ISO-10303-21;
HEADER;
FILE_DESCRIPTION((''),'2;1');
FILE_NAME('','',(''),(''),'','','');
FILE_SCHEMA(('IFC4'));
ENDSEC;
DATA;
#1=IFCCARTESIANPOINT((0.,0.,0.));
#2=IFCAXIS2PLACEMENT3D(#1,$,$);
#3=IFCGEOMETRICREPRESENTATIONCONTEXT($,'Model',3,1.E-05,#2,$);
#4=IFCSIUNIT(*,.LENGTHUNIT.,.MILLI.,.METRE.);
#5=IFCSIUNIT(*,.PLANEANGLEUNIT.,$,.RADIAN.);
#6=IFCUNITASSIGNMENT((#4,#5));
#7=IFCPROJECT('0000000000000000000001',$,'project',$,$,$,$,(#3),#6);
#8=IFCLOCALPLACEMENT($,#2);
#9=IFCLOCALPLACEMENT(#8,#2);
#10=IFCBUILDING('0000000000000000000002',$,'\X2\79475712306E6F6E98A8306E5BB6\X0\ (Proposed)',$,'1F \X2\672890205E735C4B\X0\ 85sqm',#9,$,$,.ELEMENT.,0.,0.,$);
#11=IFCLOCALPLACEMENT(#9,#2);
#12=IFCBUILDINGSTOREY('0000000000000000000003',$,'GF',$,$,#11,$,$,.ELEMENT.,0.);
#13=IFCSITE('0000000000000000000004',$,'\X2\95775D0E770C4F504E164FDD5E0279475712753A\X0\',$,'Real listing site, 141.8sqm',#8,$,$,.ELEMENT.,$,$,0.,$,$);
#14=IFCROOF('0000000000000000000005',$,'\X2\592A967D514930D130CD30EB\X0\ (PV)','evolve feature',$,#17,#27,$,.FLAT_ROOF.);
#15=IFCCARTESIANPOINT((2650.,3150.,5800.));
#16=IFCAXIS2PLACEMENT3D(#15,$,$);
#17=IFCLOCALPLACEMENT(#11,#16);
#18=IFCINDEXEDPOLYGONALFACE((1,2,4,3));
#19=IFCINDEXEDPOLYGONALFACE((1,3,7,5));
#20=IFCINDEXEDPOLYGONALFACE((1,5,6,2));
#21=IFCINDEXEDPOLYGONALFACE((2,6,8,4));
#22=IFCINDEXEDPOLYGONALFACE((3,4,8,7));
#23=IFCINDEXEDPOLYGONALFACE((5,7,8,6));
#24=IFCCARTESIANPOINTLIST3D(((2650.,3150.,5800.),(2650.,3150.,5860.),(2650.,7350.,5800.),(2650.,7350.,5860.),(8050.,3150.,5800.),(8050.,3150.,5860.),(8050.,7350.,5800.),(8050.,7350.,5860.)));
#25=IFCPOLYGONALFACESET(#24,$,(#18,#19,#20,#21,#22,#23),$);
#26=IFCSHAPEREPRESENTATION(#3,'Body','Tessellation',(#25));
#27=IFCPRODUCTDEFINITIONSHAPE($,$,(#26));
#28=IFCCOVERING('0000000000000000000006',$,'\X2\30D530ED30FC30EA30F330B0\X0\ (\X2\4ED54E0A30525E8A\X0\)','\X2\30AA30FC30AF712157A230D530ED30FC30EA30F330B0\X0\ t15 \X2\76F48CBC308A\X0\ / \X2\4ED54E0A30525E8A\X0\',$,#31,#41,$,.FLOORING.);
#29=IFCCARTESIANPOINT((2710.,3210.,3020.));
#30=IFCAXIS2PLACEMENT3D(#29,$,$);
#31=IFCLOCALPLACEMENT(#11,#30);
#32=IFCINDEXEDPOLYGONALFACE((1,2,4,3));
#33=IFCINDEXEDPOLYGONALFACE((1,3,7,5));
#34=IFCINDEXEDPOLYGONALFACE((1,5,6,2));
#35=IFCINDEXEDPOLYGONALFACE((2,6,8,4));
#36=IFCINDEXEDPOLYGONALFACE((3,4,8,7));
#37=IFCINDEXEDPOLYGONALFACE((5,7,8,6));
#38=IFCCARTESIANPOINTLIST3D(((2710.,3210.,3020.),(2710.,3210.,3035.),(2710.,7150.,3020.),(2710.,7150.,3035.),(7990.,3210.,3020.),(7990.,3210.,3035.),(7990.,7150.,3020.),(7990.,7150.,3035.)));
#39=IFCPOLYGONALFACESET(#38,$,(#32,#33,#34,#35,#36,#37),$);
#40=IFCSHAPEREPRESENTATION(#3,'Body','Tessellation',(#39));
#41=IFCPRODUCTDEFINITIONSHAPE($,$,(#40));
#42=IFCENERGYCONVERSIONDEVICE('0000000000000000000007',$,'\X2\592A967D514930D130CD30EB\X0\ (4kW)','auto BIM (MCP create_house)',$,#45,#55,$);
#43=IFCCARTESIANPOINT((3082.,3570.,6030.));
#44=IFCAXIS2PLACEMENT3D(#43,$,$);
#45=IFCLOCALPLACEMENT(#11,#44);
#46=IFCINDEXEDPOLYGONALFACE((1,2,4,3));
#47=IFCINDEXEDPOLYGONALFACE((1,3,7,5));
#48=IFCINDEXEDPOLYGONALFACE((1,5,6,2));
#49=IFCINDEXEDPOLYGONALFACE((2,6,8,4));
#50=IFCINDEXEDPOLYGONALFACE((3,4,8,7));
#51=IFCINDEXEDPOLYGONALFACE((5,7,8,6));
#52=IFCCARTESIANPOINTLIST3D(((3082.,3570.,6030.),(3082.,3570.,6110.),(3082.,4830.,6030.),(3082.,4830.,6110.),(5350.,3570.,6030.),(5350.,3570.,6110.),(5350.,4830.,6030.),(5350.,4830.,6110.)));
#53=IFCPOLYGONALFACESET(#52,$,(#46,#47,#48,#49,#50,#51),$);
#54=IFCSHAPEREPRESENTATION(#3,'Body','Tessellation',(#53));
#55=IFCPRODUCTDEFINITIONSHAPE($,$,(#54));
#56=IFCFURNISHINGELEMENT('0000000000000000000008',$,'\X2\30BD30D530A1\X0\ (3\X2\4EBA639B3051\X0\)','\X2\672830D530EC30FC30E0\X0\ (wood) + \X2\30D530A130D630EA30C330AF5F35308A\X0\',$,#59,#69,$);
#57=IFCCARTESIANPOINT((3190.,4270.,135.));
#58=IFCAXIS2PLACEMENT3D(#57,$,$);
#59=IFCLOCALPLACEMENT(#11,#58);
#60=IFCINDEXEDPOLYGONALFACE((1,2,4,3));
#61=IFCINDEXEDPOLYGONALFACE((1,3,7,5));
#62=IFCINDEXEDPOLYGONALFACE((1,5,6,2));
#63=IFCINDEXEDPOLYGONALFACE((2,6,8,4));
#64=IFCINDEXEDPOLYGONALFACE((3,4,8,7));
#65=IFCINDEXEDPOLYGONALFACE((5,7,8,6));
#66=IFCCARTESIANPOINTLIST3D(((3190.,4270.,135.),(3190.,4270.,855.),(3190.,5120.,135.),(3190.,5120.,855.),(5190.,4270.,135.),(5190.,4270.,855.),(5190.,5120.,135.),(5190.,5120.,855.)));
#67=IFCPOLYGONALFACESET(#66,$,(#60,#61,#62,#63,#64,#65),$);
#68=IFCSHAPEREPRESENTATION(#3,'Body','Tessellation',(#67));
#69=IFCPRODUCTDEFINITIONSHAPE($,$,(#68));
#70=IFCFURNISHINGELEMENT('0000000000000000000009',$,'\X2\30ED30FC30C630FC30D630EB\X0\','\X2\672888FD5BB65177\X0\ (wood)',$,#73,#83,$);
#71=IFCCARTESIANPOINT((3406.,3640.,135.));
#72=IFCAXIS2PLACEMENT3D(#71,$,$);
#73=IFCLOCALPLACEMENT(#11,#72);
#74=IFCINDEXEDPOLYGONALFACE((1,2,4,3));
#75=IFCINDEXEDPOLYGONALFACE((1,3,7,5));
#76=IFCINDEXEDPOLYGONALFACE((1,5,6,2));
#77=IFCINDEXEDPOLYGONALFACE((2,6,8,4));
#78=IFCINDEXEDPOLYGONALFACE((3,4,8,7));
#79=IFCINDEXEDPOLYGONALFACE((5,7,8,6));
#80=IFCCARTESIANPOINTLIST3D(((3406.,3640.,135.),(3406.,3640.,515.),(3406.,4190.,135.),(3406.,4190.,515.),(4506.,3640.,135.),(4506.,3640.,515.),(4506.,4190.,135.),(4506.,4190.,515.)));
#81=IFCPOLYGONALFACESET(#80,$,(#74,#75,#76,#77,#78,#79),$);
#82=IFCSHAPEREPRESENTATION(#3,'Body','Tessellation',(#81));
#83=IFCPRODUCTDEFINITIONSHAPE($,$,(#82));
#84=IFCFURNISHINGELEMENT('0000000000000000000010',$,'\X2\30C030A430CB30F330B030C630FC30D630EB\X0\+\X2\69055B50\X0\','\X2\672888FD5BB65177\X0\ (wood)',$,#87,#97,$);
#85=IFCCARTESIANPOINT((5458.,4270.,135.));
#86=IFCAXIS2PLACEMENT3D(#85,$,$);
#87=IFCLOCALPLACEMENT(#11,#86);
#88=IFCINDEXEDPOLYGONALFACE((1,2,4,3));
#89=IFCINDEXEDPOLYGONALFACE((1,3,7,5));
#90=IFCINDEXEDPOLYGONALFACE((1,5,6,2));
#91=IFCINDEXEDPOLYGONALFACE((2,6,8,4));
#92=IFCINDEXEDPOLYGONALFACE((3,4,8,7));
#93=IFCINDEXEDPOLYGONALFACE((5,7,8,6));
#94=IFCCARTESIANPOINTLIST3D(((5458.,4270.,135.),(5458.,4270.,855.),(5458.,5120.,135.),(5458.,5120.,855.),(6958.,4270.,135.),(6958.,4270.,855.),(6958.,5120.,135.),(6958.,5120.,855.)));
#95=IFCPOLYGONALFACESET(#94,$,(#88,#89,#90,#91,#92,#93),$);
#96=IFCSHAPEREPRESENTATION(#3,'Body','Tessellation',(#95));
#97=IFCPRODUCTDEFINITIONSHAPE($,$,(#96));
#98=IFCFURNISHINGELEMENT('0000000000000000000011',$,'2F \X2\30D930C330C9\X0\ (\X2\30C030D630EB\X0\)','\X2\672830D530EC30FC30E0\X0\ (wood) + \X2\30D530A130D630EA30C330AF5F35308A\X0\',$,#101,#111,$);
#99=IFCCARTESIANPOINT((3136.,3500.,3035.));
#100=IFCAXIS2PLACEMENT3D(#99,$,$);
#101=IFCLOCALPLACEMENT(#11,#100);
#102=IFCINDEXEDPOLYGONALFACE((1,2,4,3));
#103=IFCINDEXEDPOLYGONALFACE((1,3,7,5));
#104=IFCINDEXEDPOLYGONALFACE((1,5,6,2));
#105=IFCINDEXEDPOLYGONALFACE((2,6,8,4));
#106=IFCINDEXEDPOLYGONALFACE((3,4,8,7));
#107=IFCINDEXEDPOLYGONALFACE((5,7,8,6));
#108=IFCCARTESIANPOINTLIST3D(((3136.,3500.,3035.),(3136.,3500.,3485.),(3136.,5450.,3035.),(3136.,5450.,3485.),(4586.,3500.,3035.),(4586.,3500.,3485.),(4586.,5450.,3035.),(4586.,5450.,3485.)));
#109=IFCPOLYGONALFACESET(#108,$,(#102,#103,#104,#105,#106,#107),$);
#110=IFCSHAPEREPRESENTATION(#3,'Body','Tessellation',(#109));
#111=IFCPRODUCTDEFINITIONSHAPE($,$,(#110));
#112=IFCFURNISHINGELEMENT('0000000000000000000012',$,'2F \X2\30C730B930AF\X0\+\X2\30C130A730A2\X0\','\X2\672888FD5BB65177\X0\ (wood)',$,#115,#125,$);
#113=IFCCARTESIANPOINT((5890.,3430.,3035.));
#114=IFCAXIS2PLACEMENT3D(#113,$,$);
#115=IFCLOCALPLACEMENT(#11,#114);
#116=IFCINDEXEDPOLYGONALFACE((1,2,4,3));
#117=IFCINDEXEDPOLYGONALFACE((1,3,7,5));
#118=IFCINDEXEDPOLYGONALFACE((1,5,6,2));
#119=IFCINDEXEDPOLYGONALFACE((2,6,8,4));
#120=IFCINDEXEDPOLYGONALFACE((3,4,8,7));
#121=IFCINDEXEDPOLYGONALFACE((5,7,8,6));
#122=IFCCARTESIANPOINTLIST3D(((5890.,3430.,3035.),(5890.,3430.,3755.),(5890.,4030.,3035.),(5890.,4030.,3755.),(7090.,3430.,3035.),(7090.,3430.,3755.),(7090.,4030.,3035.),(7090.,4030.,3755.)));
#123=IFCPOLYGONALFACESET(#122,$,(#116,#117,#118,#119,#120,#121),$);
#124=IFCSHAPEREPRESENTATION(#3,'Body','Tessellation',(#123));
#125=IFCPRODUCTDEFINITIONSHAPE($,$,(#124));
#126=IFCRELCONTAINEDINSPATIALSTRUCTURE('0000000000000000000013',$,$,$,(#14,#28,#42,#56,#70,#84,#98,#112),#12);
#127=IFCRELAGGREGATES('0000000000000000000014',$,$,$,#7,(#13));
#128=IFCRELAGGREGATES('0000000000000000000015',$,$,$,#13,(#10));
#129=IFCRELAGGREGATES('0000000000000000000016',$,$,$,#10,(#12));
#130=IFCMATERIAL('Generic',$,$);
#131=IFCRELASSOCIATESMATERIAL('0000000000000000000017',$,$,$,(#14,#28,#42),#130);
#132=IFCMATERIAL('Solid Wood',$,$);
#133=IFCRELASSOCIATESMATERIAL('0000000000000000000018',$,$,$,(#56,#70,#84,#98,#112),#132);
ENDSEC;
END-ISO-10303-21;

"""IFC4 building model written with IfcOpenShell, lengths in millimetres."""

from ifc_helpers import new_model, si_unit, frame, frame_2d, origin, place, context, project, spatial, rectangle, extrude, material, element, save


model = new_model("IFC4")

# Units and contexts
model_context = context("Model", 3, precision=1e-05, world=origin())
ifc_project = project(units=[si_unit("LENGTHUNIT", "METRE", prefix="MILLI"), si_unit("PLANEANGLEUNIT", "RADIAN")], contexts=[model_context])

# Site, building, storey
site_placement = place(None, origin())
site = spatial("IfcSite", under=ifc_project, at=site_placement, Name="長崎県佐世保市祇園町", ObjectType="Real listing site, 141.8sqm", CompositionType="ELEMENT", RefElevation=0.0)
building_placement = place(site_placement, origin())
building = spatial("IfcBuilding", under=site, at=building_placement, Name="祇園の潮風の家 (Proposed)", ObjectType="1F 木造平屋 85sqm", CompositionType="ELEMENT", ElevationOfRefHeight=0.0, ElevationOfTerrain=0.0)
storey_placement = place(building_placement, origin())
storey = spatial("IfcBuildingStorey", under=building, at=storey_placement, Name="GF", CompositionType="ELEMENT", Elevation=0.0)

# Shared definitions
ifc_material_1 = material(Name="Solid Wood")

# Shared definitions
ifc_material_2 = material(Name="Generic")

# Roof
roof_placement = place(storey_placement, frame((2650.0, 3150.0, 5800.0)))
element("IfcRoof", 1, at=roof_placement, inside=storey, material=ifc_material_2, Name="太陽光パネル (PV)", Description="evolve feature", PredefinedType="FLAT_ROOF", context=model_context, shape_type="SweptSolid", body=[
    extrude(rectangle(XDim=5400.0, YDim=4200.0, at=frame_2d((2700.0, 2100.0))), frame((2650.0, 3150.0, 5800.0)), (0.0, 0.0, 1.0), 60.0),
])

# Covering
covering_placement = place(storey_placement, frame((2710.0, 3210.0, 3020.0)))
element("IfcCovering", 2, at=covering_placement, inside=storey, material=ifc_material_2, Name="フローリング (仕上げ床)", Description="オーク無垢フローリング t15 直貼り / 仕上げ床", PredefinedType="FLOORING", context=model_context, shape_type="SweptSolid", body=[
    extrude(rectangle(XDim=5280.0, YDim=3940.0, at=frame_2d((2640.0, 1970.0))), frame((2710.0, 3210.0, 3020.0)), (0.0, 0.0, 1.0), 15.0),
])

# Energy conversion device
energy_conversion_device_placement = place(storey_placement, frame((3082.0, 3570.0, 6030.0)))
element("IfcEnergyConversionDevice", 3, at=energy_conversion_device_placement, inside=storey, material=ifc_material_2, Name="太陽光パネル (4kW)", Description="auto BIM (MCP create_house)", context=model_context, shape_type="SweptSolid", body=[
    extrude(rectangle(XDim=2268.0, YDim=1260.0, at=frame_2d((1134.0, 630.0))), frame((3082.0, 3570.0, 6030.0)), (0.0, 0.0, 1.0), 80.0),
])

# Furnishing elements
furnishing_1_placement = place(storey_placement, frame((3190.0, 4270.0, 135.0)))
element("IfcFurnishingElement", 4, at=furnishing_1_placement, inside=storey, material=ifc_material_1, Name="ソファ (3人掛け)", Description="木フレーム (wood) + ファブリック張り", context=model_context, shape_type="SweptSolid", body=[
    extrude(rectangle(XDim=2000.0, YDim=850.0, at=frame_2d((1000.0, 425.0))), frame((3190.0, 4270.0, 135.0)), (0.0, 0.0, 1.0), 720.0),
])
furnishing_2_placement = place(storey_placement, frame((3406.0, 3640.0, 135.0)))
element("IfcFurnishingElement", 5, at=furnishing_2_placement, inside=storey, material=ifc_material_1, Name="ローテーブル", Description="木製家具 (wood)", context=model_context, shape_type="SweptSolid", body=[
    extrude(rectangle(XDim=1100.0, YDim=550.0, at=frame_2d((550.0, 275.0))), frame((3406.0, 3640.0, 135.0)), (0.0, 0.0, 1.0), 380.0),
])
furnishing_3_placement = place(storey_placement, frame((5458.0, 4270.0, 135.0)))
element("IfcFurnishingElement", 6, at=furnishing_3_placement, inside=storey, material=ifc_material_1, Name="ダイニングテーブル+椅子", Description="木製家具 (wood)", context=model_context, shape_type="SweptSolid", body=[
    extrude(rectangle(XDim=1500.0, YDim=850.0, at=frame_2d((750.0, 425.0))), frame((5458.0, 4270.0, 135.0)), (0.0, 0.0, 1.0), 720.0),
])
furnishing_4_placement = place(storey_placement, frame((3136.0, 3500.0, 3035.0)))
element("IfcFurnishingElement", 7, at=furnishing_4_placement, inside=storey, material=ifc_material_1, Name="2F ベッド (ダブル)", Description="木フレーム (wood) + ファブリック張り", context=model_context, shape_type="SweptSolid", body=[
    extrude(rectangle(XDim=1450.0, YDim=1950.0, at=frame_2d((725.0, 975.0))), frame((3136.0, 3500.0, 3035.0)), (0.0, 0.0, 1.0), 450.0),
])
furnishing_5_placement = place(storey_placement, frame((5890.0, 3430.0, 3035.0)))
element("IfcFurnishingElement", 8, at=furnishing_5_placement, inside=storey, material=ifc_material_1, Name="2F デスク+チェア", Description="木製家具 (wood)", context=model_context, shape_type="SweptSolid", body=[
    extrude(rectangle(XDim=1200.0, YDim=600.0, at=frame_2d((600.0, 300.0))), frame((5890.0, 3430.0, 3035.0)), (0.0, 0.0, 1.0), 720.0),
])

save(model, "model.ifc")
